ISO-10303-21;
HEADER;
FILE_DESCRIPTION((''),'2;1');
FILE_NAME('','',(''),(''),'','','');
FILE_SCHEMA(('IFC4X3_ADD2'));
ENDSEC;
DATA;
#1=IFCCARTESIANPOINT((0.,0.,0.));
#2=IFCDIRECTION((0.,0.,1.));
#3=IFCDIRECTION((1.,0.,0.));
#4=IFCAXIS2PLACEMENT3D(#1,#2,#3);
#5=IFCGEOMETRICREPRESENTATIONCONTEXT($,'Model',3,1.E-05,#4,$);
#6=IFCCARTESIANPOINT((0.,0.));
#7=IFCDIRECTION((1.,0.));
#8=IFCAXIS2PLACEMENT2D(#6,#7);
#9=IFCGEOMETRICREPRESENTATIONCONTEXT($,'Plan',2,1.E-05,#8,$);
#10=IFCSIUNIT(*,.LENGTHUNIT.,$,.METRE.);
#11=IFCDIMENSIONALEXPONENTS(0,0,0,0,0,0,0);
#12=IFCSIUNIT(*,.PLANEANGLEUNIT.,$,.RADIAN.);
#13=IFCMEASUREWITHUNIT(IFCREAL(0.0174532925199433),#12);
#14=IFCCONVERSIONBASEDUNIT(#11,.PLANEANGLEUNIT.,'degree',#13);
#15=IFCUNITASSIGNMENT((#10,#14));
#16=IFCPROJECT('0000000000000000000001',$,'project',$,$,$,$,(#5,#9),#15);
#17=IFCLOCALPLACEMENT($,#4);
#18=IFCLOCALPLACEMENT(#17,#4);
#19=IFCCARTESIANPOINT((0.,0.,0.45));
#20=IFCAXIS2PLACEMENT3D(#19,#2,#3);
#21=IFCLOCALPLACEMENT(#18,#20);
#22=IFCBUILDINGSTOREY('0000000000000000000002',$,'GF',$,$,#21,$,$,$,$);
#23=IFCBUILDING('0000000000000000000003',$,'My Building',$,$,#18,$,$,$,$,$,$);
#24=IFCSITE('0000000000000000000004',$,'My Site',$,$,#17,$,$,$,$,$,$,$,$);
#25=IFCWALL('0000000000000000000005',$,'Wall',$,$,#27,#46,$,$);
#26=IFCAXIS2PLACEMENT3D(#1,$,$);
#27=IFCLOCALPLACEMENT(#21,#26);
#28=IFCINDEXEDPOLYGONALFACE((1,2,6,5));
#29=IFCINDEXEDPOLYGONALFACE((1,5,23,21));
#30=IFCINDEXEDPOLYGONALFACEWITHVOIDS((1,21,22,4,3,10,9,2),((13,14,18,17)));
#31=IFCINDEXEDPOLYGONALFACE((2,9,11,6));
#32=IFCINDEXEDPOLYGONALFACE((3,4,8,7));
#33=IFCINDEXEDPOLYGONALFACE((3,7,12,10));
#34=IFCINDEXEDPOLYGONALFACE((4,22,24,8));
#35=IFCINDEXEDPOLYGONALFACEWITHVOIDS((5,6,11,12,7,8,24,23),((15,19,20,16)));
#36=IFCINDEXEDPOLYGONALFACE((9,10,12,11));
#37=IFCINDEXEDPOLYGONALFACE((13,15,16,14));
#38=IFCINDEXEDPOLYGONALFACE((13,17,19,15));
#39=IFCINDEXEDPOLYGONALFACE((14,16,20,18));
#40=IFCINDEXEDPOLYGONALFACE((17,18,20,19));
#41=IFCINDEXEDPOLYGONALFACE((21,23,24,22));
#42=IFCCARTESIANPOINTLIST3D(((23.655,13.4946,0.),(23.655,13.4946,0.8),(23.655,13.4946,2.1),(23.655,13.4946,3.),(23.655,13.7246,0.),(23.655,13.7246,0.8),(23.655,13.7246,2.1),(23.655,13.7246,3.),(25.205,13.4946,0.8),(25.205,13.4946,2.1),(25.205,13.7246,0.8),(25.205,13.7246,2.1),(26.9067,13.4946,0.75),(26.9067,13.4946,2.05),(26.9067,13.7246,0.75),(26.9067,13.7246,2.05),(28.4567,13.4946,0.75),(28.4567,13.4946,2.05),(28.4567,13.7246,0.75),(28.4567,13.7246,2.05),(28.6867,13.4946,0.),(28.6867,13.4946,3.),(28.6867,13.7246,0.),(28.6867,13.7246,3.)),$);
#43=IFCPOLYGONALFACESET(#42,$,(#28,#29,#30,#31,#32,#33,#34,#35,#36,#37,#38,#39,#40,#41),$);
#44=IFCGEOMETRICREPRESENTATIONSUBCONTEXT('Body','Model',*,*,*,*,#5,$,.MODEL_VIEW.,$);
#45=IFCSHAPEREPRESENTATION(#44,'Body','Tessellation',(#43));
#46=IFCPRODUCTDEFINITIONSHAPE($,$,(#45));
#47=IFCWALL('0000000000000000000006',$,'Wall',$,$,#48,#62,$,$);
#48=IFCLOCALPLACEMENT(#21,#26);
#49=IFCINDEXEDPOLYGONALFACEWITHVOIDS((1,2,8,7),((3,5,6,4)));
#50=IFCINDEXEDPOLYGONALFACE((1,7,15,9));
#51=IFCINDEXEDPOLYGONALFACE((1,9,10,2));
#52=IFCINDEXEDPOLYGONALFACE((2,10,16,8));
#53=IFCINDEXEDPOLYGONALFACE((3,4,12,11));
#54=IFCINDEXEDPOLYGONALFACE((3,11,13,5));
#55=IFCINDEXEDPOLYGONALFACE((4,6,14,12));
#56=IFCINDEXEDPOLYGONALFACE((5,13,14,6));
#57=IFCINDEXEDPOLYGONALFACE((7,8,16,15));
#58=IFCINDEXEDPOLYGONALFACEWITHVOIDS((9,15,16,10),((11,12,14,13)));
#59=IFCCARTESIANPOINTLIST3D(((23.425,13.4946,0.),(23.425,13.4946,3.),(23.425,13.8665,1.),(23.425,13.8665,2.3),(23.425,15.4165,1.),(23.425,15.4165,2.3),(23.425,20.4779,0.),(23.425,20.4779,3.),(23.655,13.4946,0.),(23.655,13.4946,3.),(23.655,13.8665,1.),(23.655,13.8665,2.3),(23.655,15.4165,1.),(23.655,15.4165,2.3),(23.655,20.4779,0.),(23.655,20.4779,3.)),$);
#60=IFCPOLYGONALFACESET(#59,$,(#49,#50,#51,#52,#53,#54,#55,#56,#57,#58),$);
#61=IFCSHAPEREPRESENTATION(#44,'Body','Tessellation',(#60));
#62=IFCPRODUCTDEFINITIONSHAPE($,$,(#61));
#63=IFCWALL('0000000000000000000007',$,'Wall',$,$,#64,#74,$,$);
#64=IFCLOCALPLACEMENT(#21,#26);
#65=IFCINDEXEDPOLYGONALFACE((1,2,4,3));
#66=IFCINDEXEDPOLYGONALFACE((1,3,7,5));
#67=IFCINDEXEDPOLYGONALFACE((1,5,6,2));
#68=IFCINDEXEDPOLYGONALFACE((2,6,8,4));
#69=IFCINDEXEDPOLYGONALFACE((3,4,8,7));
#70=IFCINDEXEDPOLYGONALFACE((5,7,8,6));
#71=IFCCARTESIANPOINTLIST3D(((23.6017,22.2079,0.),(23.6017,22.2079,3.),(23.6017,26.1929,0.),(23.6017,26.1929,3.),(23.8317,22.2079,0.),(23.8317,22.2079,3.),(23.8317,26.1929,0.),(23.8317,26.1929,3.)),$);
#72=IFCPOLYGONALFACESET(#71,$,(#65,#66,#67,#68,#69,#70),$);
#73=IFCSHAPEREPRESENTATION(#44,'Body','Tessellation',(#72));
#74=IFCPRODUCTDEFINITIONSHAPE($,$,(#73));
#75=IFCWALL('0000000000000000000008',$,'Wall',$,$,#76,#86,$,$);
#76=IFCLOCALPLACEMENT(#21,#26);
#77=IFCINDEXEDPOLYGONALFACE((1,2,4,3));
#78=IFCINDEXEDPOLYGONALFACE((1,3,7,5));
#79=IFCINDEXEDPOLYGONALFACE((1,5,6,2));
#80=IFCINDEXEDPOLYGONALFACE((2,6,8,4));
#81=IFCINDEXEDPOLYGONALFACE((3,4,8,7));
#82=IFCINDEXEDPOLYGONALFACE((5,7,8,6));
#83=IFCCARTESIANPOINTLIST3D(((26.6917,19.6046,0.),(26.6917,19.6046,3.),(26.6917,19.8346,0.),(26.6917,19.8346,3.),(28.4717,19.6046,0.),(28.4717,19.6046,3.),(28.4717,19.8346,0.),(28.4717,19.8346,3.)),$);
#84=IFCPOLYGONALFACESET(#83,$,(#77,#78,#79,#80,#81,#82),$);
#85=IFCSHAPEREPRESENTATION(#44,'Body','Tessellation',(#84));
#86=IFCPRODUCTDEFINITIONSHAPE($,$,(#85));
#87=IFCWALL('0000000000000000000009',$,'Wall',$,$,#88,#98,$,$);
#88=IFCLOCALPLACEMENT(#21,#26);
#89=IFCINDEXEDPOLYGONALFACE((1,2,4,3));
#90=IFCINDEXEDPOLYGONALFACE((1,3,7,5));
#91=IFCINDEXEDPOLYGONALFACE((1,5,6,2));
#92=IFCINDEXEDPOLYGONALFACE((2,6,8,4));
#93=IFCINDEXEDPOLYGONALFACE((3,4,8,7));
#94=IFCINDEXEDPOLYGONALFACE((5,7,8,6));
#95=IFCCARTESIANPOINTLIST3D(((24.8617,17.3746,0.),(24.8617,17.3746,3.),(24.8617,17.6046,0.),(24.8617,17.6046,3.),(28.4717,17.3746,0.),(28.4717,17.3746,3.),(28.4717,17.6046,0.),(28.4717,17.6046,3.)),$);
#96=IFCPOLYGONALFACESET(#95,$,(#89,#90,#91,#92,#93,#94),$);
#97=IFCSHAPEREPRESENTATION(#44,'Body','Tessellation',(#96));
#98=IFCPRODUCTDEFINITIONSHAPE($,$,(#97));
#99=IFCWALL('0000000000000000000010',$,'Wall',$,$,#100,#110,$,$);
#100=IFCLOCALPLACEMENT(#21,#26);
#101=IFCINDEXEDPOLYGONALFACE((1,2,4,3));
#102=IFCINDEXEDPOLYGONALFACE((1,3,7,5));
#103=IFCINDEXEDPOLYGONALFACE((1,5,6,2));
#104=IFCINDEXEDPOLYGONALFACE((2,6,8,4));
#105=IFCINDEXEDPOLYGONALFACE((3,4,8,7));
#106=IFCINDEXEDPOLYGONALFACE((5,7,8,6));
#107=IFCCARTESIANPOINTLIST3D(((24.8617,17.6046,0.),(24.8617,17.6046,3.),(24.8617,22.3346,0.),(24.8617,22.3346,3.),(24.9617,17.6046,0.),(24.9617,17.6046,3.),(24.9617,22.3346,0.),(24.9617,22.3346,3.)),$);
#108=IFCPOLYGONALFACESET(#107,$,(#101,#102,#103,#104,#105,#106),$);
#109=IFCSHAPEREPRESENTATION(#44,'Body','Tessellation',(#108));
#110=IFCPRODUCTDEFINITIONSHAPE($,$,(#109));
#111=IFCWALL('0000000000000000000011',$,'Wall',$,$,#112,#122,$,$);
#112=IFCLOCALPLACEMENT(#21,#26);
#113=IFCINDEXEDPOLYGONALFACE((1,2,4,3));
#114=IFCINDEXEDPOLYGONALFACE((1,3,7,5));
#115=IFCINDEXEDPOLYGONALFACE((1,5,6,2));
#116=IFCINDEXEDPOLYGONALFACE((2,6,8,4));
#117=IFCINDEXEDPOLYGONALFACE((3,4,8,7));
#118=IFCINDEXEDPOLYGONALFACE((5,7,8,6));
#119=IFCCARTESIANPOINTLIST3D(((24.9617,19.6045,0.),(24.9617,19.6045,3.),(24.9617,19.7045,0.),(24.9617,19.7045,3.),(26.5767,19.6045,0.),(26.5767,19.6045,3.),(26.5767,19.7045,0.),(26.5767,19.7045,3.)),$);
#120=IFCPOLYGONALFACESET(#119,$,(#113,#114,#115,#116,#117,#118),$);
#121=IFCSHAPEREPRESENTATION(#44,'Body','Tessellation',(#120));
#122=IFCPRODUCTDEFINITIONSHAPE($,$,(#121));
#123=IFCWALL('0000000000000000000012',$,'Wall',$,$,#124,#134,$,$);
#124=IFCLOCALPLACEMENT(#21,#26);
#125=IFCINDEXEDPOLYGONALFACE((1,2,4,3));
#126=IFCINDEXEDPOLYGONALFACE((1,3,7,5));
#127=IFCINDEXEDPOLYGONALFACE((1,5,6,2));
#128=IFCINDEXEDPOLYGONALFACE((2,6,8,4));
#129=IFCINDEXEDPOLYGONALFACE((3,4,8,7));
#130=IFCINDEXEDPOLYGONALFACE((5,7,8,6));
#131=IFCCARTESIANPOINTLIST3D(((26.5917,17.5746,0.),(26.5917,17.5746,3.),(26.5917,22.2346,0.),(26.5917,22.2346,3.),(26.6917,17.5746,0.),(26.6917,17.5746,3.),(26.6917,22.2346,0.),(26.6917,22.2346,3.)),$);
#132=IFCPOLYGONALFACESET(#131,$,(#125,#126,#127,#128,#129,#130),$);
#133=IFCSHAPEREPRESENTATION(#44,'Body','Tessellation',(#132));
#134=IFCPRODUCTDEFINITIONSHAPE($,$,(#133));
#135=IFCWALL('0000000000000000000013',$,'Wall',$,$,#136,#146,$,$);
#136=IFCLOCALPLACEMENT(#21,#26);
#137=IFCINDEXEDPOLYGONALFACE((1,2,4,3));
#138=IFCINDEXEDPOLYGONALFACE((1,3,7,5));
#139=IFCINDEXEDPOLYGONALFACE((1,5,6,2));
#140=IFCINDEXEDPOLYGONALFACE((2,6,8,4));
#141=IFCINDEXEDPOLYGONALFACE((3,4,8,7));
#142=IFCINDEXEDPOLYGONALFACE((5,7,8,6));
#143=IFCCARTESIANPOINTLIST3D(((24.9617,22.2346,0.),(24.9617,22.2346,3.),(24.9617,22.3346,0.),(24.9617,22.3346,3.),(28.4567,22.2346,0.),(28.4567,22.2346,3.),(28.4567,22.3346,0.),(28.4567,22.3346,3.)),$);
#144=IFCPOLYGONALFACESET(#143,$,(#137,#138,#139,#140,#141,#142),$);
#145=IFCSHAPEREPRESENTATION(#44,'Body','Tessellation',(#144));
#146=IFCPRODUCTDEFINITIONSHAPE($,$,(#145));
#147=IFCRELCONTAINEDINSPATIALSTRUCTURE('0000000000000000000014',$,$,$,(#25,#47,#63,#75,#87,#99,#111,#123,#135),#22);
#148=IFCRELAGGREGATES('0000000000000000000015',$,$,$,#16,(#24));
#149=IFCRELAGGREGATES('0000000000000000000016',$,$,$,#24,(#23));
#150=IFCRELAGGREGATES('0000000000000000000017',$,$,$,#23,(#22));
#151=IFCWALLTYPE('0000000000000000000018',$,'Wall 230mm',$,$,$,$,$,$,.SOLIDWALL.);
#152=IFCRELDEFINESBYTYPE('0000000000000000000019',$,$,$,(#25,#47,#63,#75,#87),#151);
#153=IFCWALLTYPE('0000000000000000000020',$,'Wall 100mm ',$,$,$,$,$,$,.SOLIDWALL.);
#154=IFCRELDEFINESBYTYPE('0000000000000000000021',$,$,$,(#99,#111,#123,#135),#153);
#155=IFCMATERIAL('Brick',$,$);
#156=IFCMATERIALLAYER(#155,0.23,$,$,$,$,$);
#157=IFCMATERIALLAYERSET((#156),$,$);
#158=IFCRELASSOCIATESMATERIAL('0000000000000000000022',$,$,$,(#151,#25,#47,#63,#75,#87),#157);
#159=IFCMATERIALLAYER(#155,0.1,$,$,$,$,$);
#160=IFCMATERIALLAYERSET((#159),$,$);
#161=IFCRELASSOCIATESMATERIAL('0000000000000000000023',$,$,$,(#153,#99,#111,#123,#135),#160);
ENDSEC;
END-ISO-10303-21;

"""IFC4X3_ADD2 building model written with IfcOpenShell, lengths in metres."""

from ifc_helpers import new_model, entity, si_unit, converted_unit, frame, origin_with_axes, origin_2d_with_axis, place, context, subcontext, project, spatial, line, indexed_curve, outline, extrude, source, transform, mapped, material, layer, layer_set, layer_usage, type_object, element, save


model = new_model("IFC4X3_ADD2")

# Units and contexts
model_context = context("Model", 3, precision=1e-05, world=origin_with_axes())
plan_context = context("Plan", 2, precision=1e-05, world=origin_2d_with_axis())
body_context_1 = subcontext(model_context, "Body", "Model", "MODEL_VIEW")
ifc_project = project(units=[si_unit("LENGTHUNIT", "METRE"), converted_unit("PLANEANGLEUNIT", "degree", entity("IfcReal", 0.0174532925199433), si_unit("PLANEANGLEUNIT", "RADIAN"), dimensions=[0, 0, 0, 0, 0, 0, 0])], contexts=[model_context, plan_context])

# Site, building, storey
site_placement = place(None, origin_with_axes())
site = spatial("IfcSite", under=ifc_project, at=site_placement, Name="My Site")
building_placement = place(site_placement, origin_with_axes())
building = spatial("IfcBuilding", under=site, at=building_placement, Name="My Building")
storey_placement = place(building_placement, frame((0.0, 0.0, 0.45), z_axis=(0.0, 0.0, 1.0), x_axis=(1.0, 0.0, 0.0)))
storey = spatial("IfcBuildingStorey", under=building, at=storey_placement, Name="GF")

# Wall, openings
ifc_material = material(Name="Brick")
ifc_layer_1 = layer(ifc_material, 0.23)
ifc_layer_set_1 = layer_set([ifc_layer_1])
wall_type_1 = type_object("IfcWallType", Name="Wall 230mm", PredefinedType="SOLIDWALL", material=ifc_layer_set_1)
ifc_layer_usage_1 = layer_usage(ifc_layer_set_1, "AXIS2", "POSITIVE", 0.0)
wall_1_placement = place(storey_placement, frame((23.655, 13.4946, 0.0), z_axis=(0.0, 0.0, 1.0), x_axis=(1.0, 0.0, 0.0)))
wall_1 = element("IfcWall", 1, at=wall_1_placement, inside=storey, type_object=wall_type_1, material=ifc_layer_usage_1, Name="Wall", context=body_context_1, shape_type="SweptSolid", body=[
    extrude(outline(indexed_curve([(0.0, 0.0), (0.0, 0.23), (5.0317, 0.23), (5.0317, 0.0), (0.0, 0.0)], self_intersect=False)), origin_with_axes(), (0.0, 0.0, 1.0), 3.0),
])
shared_shape_1 = source(origin_with_axes(), body_context_1, "Body", "SweptSolid", [
    extrude(outline(indexed_curve([(0.0, 0.0), (1.55, 0.0), (1.55, 1.3), (0.0, 1.3)], segments=[line(1, 2, 3, 4, 1)])), frame((-0.775, -0.6, 0.0), z_axis=(0.0, -1.0, 0.0), x_axis=(1.0, 0.0, 0.0)), (0.0, 0.0, -1.0), 1.2),
])
opening_1_placement = place(wall_1_placement, frame((0.775, 0.0, 0.8), z_axis=(0.0, 0.0, 1.0), x_axis=(1.0, 0.0, 0.0)))
element("IfcOpeningElement", 2, at=opening_1_placement, cuts=wall_1, PredefinedType="OPENING", context=body_context_1, shape_type="MappedRepresentation", body=[
    mapped(shared_shape_1, transform((0.0, 0.0, 0.0), x_axis=(1.0, 0.0, 0.0), y_axis=(0.0, 1.0, 0.0), z_axis=(0.0, 0.0, 1.0), scale=1.0)),
])
opening_2_placement = place(wall_1_placement, frame((4.0267, 0.0, 0.75), z_axis=(0.0, 0.0, 1.0), x_axis=(1.0, 0.0, 0.0)))
element("IfcOpeningElement", 3, at=opening_2_placement, cuts=wall_1, PredefinedType="OPENING", context=body_context_1, shape_type="MappedRepresentation", body=[
    mapped(shared_shape_1, transform((0.0, 0.0, 0.0), x_axis=(1.0, 0.0, 0.0), y_axis=(0.0, 1.0, 0.0), z_axis=(0.0, 0.0, 1.0), scale=1.0)),
])

# Wall, opening
ifc_layer_usage_2 = layer_usage(ifc_layer_set_1, "AXIS2", "POSITIVE", 0.0)
wall_2_placement = place(storey_placement, frame((23.655, 13.4946, 0.0), z_axis=(0.0, 0.0, 1.0), x_axis=(0.0, 1.0, 0.0)))
wall_2 = element("IfcWall", 4, at=wall_2_placement, inside=storey, type_object=wall_type_1, material=ifc_layer_usage_2, Name="Wall", context=body_context_1, shape_type="SweptSolid", body=[
    extrude(outline(indexed_curve([(0.0, 0.0), (0.0, 0.23), (6.9833, 0.23), (6.9833, 0.0), (0.0, 0.0)], self_intersect=False)), origin_with_axes(), (0.0, 0.0, 1.0), 3.0),
])
opening_3_placement = place(wall_2_placement, frame((1.1469, 0.2088, 1.0), z_axis=(0.0, 0.0, 1.0), x_axis=(-1.0, 0.0, 0.0)))
element("IfcOpeningElement", 5, at=opening_3_placement, cuts=wall_2, PredefinedType="OPENING", context=body_context_1, shape_type="MappedRepresentation", body=[
    mapped(shared_shape_1, transform((0.0, 0.0, 0.0), x_axis=(1.0, 0.0, 0.0), y_axis=(0.0, 1.0, 0.0), z_axis=(0.0, 0.0, 1.0), scale=1.0)),
])

# Walls
ifc_layer_usage_3 = layer_usage(ifc_layer_set_1, "AXIS2", "POSITIVE", 0.0)
wall_3_placement = place(storey_placement, frame((23.8317, 22.2079, 0.0), z_axis=(0.0, 0.0, 1.0), x_axis=(0.0, 1.0, 0.0)))
element("IfcWall", 6, at=wall_3_placement, inside=storey, type_object=wall_type_1, material=ifc_layer_usage_3, Name="Wall", context=body_context_1, shape_type="SweptSolid", body=[
    extrude(outline(indexed_curve([(0.0, 0.0), (0.0, 0.23), (3.985, 0.23), (3.985, 0.0), (0.0, 0.0)], self_intersect=False)), origin_with_axes(), (0.0, 0.0, 1.0), 3.0),
])
ifc_layer_usage_4 = layer_usage(ifc_layer_set_1, "AXIS2", "POSITIVE", 0.0)
wall_4_placement = place(storey_placement, frame((26.6917, 19.6046, 0.0), z_axis=(0.0, 0.0, 1.0), x_axis=(1.0, 0.0, 0.0)))
element("IfcWall", 7, at=wall_4_placement, inside=storey, type_object=wall_type_1, material=ifc_layer_usage_4, Name="Wall", context=body_context_1, shape_type="SweptSolid", body=[
    extrude(outline(indexed_curve([(0.0, 0.0), (0.0, 0.23), (1.78, 0.23), (1.78, 0.0), (0.0, 0.0)], self_intersect=False)), origin_with_axes(), (0.0, 0.0, 1.0), 3.0),
])
ifc_layer_usage_5 = layer_usage(ifc_layer_set_1, "AXIS2", "POSITIVE", 0.0)
wall_5_placement = place(storey_placement, frame((24.8617, 17.3746, 0.0), z_axis=(0.0, 0.0, 1.0), x_axis=(1.0, 0.0, 0.0)))
element("IfcWall", 8, at=wall_5_placement, inside=storey, type_object=wall_type_1, material=ifc_layer_usage_5, Name="Wall", context=body_context_1, shape_type="SweptSolid", body=[
    extrude(outline(indexed_curve([(0.0, 0.0), (0.0, 0.23), (3.61, 0.23), (3.61, 0.0), (0.0, 0.0)], self_intersect=False)), origin_with_axes(), (0.0, 0.0, 1.0), 3.0),
])
ifc_layer_2 = layer(ifc_material, 0.1)
ifc_layer_set_2 = layer_set([ifc_layer_2])
ifc_layer_usage_6 = layer_usage(ifc_layer_set_2, "AXIS2", "POSITIVE", 0.0)
wall_type_2 = type_object("IfcWallType", Name="Wall 100mm ", PredefinedType="SOLIDWALL", material=ifc_layer_set_2)
wall_6_placement = place(storey_placement, frame((24.9617, 17.6046, 0.0), z_axis=(0.0, 0.0, 1.0), x_axis=(0.0, 1.0, 0.0)))
element("IfcWall", 9, at=wall_6_placement, inside=storey, type_object=wall_type_2, material=ifc_layer_usage_6, Name="Wall", context=body_context_1, shape_type="SweptSolid", body=[
    extrude(outline(indexed_curve([(0.0, 0.0), (0.0, 0.1), (4.73, 0.1), (4.73, 0.0), (0.0, 0.0)], self_intersect=False)), origin_with_axes(), (0.0, 0.0, 1.0), 3.0),
])
ifc_layer_usage_7 = layer_usage(ifc_layer_set_2, "AXIS2", "POSITIVE", 0.0)
wall_7_placement = place(storey_placement, frame((24.9617, 19.6045, 0.0), z_axis=(0.0, 0.0, 1.0), x_axis=(1.0, 0.0, 0.0)))
element("IfcWall", 10, at=wall_7_placement, inside=storey, type_object=wall_type_2, material=ifc_layer_usage_7, Name="Wall", context=body_context_1, shape_type="SweptSolid", body=[
    extrude(outline(indexed_curve([(0.0, 0.0), (0.0, 0.1), (1.615, 0.1), (1.615, 0.0), (0.0, 0.0)], self_intersect=False)), origin_with_axes(), (0.0, 0.0, 1.0), 3.0),
])
ifc_layer_usage_8 = layer_usage(ifc_layer_set_2, "AXIS2", "POSITIVE", 0.0)
wall_8_placement = place(storey_placement, frame((26.6917, 17.5746, 0.0), z_axis=(0.0, 0.0, 1.0), x_axis=(0.0, 1.0, 0.0)))
element("IfcWall", 11, at=wall_8_placement, inside=storey, type_object=wall_type_2, material=ifc_layer_usage_8, Name="Wall", context=body_context_1, shape_type="SweptSolid", body=[
    extrude(outline(indexed_curve([(0.0, 0.0), (0.0, 0.1), (4.66, 0.1), (4.66, 0.0), (0.0, 0.0)], self_intersect=False)), origin_with_axes(), (0.0, 0.0, 1.0), 3.0),
])
ifc_layer_usage_9 = layer_usage(ifc_layer_set_2, "AXIS2", "POSITIVE", 0.0)
wall_9_placement = place(storey_placement, frame((24.9617, 22.2346, 0.0), z_axis=(0.0, 0.0, 1.0), x_axis=(1.0, 0.0, 0.0)))
element("IfcWall", 12, at=wall_9_placement, inside=storey, type_object=wall_type_2, material=ifc_layer_usage_9, Name="Wall", context=body_context_1, shape_type="SweptSolid", body=[
    extrude(outline(indexed_curve([(0.0, 0.0), (0.0, 0.1), (3.495, 0.1), (3.495, 0.0), (0.0, 0.0)], self_intersect=False)), origin_with_axes(), (0.0, 0.0, 1.0), 3.0),
])

save(model, "model.ifc")
